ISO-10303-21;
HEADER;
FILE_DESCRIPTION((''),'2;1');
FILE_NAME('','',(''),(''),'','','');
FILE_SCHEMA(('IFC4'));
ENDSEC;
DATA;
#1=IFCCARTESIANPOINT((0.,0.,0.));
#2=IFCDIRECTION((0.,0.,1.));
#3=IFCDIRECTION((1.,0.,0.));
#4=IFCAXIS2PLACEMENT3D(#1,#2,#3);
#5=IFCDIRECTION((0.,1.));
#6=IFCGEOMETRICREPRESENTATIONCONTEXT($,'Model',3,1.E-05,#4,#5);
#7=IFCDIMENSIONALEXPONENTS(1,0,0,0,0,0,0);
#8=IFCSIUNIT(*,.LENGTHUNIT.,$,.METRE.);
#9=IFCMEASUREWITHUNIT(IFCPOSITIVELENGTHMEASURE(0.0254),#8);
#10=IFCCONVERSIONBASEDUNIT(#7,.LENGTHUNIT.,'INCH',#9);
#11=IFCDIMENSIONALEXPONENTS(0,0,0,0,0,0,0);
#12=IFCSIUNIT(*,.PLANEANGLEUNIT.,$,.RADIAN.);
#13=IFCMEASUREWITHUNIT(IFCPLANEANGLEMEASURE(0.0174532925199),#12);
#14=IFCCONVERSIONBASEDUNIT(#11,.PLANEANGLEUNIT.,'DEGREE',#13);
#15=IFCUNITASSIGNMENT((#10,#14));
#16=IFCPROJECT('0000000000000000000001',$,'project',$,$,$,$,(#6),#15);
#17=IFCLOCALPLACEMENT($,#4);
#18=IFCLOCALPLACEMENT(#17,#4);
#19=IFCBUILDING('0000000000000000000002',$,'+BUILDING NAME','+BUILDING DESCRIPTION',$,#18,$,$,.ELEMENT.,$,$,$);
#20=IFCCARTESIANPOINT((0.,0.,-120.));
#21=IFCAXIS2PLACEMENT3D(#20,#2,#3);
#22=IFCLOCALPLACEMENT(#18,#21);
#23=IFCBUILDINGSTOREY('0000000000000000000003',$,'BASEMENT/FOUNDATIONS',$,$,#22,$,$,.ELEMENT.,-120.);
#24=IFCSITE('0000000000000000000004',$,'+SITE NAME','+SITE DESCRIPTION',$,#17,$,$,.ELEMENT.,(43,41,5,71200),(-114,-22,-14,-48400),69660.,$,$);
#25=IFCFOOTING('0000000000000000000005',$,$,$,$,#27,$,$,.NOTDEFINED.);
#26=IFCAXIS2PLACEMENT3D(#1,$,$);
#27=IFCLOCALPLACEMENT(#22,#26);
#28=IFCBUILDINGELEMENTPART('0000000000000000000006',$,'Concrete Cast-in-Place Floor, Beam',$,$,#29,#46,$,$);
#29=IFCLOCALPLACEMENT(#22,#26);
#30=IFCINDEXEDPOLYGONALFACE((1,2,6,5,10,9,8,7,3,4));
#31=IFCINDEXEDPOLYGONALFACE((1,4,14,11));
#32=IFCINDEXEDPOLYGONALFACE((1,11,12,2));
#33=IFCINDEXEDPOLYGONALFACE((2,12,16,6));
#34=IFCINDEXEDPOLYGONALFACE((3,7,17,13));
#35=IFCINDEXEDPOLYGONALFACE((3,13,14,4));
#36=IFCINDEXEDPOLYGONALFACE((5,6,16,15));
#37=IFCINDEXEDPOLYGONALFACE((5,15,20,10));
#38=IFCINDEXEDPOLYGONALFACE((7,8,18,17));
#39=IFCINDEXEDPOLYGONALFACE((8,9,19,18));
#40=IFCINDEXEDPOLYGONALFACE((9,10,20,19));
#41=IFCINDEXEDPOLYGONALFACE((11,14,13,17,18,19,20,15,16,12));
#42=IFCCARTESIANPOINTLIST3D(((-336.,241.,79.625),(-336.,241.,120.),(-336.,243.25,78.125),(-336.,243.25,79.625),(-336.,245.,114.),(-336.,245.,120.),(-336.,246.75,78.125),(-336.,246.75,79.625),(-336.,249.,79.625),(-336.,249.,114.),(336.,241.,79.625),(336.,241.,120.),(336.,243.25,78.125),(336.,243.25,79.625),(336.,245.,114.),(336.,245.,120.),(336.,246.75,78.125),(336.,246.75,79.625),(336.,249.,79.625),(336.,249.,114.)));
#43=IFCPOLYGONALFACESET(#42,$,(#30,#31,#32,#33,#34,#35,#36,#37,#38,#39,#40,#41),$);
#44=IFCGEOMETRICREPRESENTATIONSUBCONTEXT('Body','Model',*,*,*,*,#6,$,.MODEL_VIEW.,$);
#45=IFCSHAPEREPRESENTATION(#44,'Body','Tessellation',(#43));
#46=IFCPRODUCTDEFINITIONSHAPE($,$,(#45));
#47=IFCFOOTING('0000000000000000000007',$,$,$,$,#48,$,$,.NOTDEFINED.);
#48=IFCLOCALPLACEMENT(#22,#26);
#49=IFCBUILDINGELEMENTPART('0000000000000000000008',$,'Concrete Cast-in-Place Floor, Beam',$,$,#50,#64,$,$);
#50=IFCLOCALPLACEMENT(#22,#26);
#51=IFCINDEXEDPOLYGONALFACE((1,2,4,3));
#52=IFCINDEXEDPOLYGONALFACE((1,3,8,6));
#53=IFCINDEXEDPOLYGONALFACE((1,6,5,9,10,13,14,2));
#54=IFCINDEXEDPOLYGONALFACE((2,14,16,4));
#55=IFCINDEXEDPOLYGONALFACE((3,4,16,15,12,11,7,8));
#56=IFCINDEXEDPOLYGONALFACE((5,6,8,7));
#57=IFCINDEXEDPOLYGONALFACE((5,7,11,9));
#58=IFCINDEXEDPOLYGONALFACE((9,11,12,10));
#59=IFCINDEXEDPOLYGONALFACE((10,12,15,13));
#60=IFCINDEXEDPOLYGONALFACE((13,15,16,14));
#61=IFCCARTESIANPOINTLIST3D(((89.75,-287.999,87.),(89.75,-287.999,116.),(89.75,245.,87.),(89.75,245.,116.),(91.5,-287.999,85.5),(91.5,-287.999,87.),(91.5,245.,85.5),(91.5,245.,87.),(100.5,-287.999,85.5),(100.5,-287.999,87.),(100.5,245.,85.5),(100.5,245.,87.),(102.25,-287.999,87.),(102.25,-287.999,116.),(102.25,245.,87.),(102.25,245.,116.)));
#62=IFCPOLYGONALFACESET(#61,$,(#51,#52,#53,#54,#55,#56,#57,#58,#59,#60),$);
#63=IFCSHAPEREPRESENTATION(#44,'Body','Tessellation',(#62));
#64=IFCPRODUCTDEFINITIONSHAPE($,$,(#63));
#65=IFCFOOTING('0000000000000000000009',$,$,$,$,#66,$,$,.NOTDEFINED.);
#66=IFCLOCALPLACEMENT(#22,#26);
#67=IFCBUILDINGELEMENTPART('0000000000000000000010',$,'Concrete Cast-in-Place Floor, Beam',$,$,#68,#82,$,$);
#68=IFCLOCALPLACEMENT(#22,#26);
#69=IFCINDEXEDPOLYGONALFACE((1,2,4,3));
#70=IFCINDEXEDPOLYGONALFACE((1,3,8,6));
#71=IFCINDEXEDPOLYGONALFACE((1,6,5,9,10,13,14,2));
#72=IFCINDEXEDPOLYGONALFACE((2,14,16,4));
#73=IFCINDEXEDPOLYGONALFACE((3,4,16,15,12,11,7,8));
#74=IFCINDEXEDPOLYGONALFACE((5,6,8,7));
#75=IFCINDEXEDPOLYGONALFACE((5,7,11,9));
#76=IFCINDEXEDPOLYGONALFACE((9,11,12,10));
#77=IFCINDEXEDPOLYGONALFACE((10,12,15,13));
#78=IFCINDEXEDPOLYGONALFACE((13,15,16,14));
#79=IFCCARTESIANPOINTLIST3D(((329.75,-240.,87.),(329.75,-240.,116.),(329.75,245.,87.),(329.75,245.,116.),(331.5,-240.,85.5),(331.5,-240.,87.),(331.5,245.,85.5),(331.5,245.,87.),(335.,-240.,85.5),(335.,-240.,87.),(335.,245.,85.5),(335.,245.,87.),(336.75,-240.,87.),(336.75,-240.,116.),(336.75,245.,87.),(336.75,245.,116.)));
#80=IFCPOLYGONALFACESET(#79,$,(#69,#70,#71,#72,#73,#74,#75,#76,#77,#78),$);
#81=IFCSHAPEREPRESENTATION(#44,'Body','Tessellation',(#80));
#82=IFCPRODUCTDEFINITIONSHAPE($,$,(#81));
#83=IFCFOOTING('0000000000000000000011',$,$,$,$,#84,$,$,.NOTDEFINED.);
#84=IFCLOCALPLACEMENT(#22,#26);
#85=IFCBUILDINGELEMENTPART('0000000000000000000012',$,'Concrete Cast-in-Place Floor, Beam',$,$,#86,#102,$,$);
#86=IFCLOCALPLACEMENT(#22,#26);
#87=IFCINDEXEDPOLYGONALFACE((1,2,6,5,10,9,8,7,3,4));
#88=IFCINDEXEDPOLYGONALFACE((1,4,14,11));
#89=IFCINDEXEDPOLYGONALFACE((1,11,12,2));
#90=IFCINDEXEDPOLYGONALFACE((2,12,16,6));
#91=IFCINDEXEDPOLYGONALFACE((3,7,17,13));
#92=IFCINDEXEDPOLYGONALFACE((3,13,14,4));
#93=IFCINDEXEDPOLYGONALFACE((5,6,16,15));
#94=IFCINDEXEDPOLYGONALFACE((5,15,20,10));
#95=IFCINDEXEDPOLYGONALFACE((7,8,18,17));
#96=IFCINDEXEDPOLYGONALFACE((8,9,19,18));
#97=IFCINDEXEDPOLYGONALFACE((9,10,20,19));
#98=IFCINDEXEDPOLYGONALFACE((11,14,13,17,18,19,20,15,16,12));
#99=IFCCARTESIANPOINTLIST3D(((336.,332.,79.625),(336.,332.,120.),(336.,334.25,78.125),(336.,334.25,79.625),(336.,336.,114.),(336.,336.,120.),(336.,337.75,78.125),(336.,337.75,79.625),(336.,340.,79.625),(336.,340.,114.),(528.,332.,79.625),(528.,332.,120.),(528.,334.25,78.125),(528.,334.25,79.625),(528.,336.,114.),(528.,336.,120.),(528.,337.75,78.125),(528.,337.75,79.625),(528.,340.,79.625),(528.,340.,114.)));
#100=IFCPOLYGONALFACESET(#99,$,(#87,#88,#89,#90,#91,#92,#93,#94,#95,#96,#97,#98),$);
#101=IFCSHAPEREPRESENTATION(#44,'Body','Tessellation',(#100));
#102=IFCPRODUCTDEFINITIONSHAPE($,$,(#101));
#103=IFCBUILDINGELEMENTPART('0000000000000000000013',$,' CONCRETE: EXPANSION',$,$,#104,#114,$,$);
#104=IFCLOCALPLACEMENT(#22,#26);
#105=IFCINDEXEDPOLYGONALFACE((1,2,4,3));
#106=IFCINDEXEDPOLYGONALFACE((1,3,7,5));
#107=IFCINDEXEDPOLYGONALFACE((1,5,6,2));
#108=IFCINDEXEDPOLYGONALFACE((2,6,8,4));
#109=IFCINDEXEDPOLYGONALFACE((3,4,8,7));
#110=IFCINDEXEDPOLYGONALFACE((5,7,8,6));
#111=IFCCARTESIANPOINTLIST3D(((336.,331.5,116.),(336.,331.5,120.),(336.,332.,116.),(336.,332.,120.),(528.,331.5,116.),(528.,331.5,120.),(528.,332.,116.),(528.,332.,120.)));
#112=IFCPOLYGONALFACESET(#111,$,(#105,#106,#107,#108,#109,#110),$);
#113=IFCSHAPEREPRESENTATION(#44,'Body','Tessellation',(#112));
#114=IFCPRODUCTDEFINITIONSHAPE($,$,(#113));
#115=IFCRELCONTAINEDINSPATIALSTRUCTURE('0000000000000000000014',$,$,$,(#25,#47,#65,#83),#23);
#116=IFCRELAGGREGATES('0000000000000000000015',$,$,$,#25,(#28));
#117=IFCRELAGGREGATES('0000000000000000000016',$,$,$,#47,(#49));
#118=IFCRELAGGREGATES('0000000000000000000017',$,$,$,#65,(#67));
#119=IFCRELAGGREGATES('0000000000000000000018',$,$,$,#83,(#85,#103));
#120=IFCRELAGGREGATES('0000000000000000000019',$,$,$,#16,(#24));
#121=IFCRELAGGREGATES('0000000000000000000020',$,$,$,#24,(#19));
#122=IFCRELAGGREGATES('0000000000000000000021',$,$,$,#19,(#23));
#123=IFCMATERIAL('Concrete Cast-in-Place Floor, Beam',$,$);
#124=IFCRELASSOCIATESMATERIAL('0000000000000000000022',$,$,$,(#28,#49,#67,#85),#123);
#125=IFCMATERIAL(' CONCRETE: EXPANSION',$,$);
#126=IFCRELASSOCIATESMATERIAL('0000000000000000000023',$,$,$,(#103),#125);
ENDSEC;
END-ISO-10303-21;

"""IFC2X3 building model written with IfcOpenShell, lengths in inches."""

from ifc_helpers import new_model, entity, si_unit, converted_unit, direction, frame, origin_with_axes, place, context, subcontext, project, spatial, polyline, outline, extrude, material, element, aggregate, save


model = new_model("IFC2X3")

# Units and contexts
model_context = context("Model", 3, precision=1e-05, world=origin_with_axes(), true_north=direction((0.0, 1.0)))
body_context = subcontext(model_context, "Body", "Model", "MODEL_VIEW")
ifc_project = project(units=[converted_unit("LENGTHUNIT", "INCH", entity("IfcPositiveLengthMeasure", 0.0254), si_unit("LENGTHUNIT", "METRE"), dimensions=[1, 0, 0, 0, 0, 0, 0]), converted_unit("PLANEANGLEUNIT", "DEGREE", entity("IfcPlaneAngleMeasure", 0.0174532925199), si_unit("PLANEANGLEUNIT", "RADIAN"), dimensions=[0, 0, 0, 0, 0, 0, 0])], contexts=[model_context])

# Site, building, storey
site_placement = place(None, origin_with_axes())
site = spatial("IfcSite", under=ifc_project, at=site_placement, Name="+SITE NAME", Description="+SITE DESCRIPTION", CompositionType="ELEMENT", RefLatitude=(43, 41, 5, 71200), RefLongitude=(-114, -22, -14, -48400), RefElevation=69660.0)
building_placement = place(site_placement, origin_with_axes())
building = spatial("IfcBuilding", under=site, at=building_placement, Name="+BUILDING NAME", Description="+BUILDING DESCRIPTION", CompositionType="ELEMENT")
storey_placement = place(building_placement, frame((0.0, 0.0, -120.0), z_axis=(0.0, 0.0, 1.0), x_axis=(1.0, 0.0, 0.0)))
storey = spatial("IfcBuildingStorey", under=building, at=storey_placement, Name="BASEMENT/FOUNDATIONS", CompositionType="ELEMENT", Elevation=-120.0)

# Footings, building element parts
footing_1_placement = place(storey_placement, frame((336.0, 245.0, 120.0), z_axis=(0.0, 0.0, 1.0), x_axis=(-1.0, 0.0, 0.0)))
footing_1 = element("IfcFooting", 1, at=footing_1_placement, inside=storey, PredefinedType="NOTDEFINED")
ifc_material_1 = material(Name="Concrete Cast-in-Place Floor, Beam")
building_element_part_1_placement = place(footing_1_placement, origin_with_axes())
building_element_part_1 = element("IfcBuildingElementPart", 2, at=building_element_part_1_placement, material=ifc_material_1, Name="Concrete Cast-in-Place Floor, Beam", context=body_context, shape_type="SweptSolid", body=[
    extrude(outline(polyline([(-4.0, 0.0), (-4.0, -40.375), (-1.75, -40.375), (-1.75, -41.875), (1.75, -41.875), (1.75, -40.375), (4.0, -40.375), (4.0, -6.0), (0.0, -6.0), (0.0, 0.0), (-4.0, 0.0)])), frame((0.0, 0.0, 0.0), z_axis=(-1.0, 0.0, 0.0), x_axis=(0.0, -1.0, 0.0)), (0.0, 0.0, -1.0), 672.0),
])
ifc_material_2 = material(Name=" CONCRETE: EXPANSION")
aggregate(footing_1, [building_element_part_1])
footing_2_placement = place(storey_placement, frame((96.0, 245.0, 116.0), z_axis=(0.0, 0.0, 1.0), x_axis=(0.0, -1.0, 0.0)))
footing_2 = element("IfcFooting", 3, at=footing_2_placement, inside=storey, PredefinedType="NOTDEFINED")
building_element_part_2_placement = place(footing_2_placement, origin_with_axes())
building_element_part_2 = element("IfcBuildingElementPart", 4, at=building_element_part_2_placement, material=ifc_material_1, Name="Concrete Cast-in-Place Floor, Beam", context=body_context, shape_type="SweptSolid", body=[
    extrude(outline(polyline([(-6.25, 0.0), (-6.25, -29.0), (-4.5, -29.0), (-4.5, -30.5), (4.5, -30.5), (4.5, -29.0), (6.25, -29.0), (6.25, 0.0), (-6.25, 0.0)])), frame((0.0, 0.0, 0.0), z_axis=(1.0, 0.0, 0.0), x_axis=(0.0, 1.0, 0.0)), (0.0, 0.0, 1.0), 532.999),
])
aggregate(footing_2, [building_element_part_2])
footing_3_placement = place(storey_placement, frame((336.0, 245.0, 116.0), z_axis=(0.0, 0.0, 1.0), x_axis=(0.0, -1.0, 0.0)))
footing_3 = element("IfcFooting", 5, at=footing_3_placement, inside=storey, PredefinedType="NOTDEFINED")
building_element_part_3_placement = place(footing_3_placement, origin_with_axes())
building_element_part_3 = element("IfcBuildingElementPart", 6, at=building_element_part_3_placement, material=ifc_material_1, Name="Concrete Cast-in-Place Floor, Beam", context=body_context, shape_type="SweptSolid", body=[
    extrude(outline(polyline([(-3.5, 0.0), (-3.5, -29.0), (-1.75, -29.0), (-1.75, -30.5), (1.75, -30.5), (1.75, -29.0), (3.5, -29.0), (3.5, 0.0), (-3.5, 0.0)])), frame((0.0, -2.75, 0.0), z_axis=(-1.0, 0.0, 0.0), x_axis=(0.0, -1.0, 0.0)), (0.0, 0.0, -1.0), 485.0),
])
aggregate(footing_3, [building_element_part_3])
footing_4_placement = place(storey_placement, frame((528.0, 336.0, 120.0), z_axis=(0.0, 0.0, 1.0), x_axis=(-1.0, 0.0, 0.0)))
footing_4 = element("IfcFooting", 7, at=footing_4_placement, inside=storey, PredefinedType="NOTDEFINED")
building_element_part_4_placement = place(footing_4_placement, origin_with_axes())
building_element_part_4 = element("IfcBuildingElementPart", 8, at=building_element_part_4_placement, material=ifc_material_1, Name="Concrete Cast-in-Place Floor, Beam", context=body_context, shape_type="SweptSolid", body=[
    extrude(outline(polyline([(-4.0, 0.0), (-4.0, -40.375), (-1.75, -40.375), (-1.75, -41.875), (1.75, -41.875), (1.75, -40.375), (4.0, -40.375), (4.0, -6.0), (0.0, -6.0), (0.0, 0.0), (-4.0, 0.0)])), frame((0.0, 0.0, 0.0), z_axis=(-1.0, 0.0, 0.0), x_axis=(0.0, -1.0, 0.0)), (0.0, 0.0, -1.0), 192.0),
])
building_element_part_5_placement = place(footing_4_placement, origin_with_axes())
building_element_part_5 = element("IfcBuildingElementPart", 9, at=building_element_part_5_placement, material=ifc_material_2, Name=" CONCRETE: EXPANSION", context=body_context, shape_type="SweptSolid", body=[
    extrude(outline(polyline([(-4.0, 0.0), (-4.5, 0.0), (-4.5, -4.0), (-4.0, -4.0), (-4.0, 0.0)])), frame((0.0, 0.0, 0.0), z_axis=(-1.0, 0.0, 0.0), x_axis=(0.0, -1.0, 0.0)), (0.0, 0.0, -1.0), 192.0),
])
aggregate(footing_4, [building_element_part_4, building_element_part_5])

save(model, "model.ifc")
